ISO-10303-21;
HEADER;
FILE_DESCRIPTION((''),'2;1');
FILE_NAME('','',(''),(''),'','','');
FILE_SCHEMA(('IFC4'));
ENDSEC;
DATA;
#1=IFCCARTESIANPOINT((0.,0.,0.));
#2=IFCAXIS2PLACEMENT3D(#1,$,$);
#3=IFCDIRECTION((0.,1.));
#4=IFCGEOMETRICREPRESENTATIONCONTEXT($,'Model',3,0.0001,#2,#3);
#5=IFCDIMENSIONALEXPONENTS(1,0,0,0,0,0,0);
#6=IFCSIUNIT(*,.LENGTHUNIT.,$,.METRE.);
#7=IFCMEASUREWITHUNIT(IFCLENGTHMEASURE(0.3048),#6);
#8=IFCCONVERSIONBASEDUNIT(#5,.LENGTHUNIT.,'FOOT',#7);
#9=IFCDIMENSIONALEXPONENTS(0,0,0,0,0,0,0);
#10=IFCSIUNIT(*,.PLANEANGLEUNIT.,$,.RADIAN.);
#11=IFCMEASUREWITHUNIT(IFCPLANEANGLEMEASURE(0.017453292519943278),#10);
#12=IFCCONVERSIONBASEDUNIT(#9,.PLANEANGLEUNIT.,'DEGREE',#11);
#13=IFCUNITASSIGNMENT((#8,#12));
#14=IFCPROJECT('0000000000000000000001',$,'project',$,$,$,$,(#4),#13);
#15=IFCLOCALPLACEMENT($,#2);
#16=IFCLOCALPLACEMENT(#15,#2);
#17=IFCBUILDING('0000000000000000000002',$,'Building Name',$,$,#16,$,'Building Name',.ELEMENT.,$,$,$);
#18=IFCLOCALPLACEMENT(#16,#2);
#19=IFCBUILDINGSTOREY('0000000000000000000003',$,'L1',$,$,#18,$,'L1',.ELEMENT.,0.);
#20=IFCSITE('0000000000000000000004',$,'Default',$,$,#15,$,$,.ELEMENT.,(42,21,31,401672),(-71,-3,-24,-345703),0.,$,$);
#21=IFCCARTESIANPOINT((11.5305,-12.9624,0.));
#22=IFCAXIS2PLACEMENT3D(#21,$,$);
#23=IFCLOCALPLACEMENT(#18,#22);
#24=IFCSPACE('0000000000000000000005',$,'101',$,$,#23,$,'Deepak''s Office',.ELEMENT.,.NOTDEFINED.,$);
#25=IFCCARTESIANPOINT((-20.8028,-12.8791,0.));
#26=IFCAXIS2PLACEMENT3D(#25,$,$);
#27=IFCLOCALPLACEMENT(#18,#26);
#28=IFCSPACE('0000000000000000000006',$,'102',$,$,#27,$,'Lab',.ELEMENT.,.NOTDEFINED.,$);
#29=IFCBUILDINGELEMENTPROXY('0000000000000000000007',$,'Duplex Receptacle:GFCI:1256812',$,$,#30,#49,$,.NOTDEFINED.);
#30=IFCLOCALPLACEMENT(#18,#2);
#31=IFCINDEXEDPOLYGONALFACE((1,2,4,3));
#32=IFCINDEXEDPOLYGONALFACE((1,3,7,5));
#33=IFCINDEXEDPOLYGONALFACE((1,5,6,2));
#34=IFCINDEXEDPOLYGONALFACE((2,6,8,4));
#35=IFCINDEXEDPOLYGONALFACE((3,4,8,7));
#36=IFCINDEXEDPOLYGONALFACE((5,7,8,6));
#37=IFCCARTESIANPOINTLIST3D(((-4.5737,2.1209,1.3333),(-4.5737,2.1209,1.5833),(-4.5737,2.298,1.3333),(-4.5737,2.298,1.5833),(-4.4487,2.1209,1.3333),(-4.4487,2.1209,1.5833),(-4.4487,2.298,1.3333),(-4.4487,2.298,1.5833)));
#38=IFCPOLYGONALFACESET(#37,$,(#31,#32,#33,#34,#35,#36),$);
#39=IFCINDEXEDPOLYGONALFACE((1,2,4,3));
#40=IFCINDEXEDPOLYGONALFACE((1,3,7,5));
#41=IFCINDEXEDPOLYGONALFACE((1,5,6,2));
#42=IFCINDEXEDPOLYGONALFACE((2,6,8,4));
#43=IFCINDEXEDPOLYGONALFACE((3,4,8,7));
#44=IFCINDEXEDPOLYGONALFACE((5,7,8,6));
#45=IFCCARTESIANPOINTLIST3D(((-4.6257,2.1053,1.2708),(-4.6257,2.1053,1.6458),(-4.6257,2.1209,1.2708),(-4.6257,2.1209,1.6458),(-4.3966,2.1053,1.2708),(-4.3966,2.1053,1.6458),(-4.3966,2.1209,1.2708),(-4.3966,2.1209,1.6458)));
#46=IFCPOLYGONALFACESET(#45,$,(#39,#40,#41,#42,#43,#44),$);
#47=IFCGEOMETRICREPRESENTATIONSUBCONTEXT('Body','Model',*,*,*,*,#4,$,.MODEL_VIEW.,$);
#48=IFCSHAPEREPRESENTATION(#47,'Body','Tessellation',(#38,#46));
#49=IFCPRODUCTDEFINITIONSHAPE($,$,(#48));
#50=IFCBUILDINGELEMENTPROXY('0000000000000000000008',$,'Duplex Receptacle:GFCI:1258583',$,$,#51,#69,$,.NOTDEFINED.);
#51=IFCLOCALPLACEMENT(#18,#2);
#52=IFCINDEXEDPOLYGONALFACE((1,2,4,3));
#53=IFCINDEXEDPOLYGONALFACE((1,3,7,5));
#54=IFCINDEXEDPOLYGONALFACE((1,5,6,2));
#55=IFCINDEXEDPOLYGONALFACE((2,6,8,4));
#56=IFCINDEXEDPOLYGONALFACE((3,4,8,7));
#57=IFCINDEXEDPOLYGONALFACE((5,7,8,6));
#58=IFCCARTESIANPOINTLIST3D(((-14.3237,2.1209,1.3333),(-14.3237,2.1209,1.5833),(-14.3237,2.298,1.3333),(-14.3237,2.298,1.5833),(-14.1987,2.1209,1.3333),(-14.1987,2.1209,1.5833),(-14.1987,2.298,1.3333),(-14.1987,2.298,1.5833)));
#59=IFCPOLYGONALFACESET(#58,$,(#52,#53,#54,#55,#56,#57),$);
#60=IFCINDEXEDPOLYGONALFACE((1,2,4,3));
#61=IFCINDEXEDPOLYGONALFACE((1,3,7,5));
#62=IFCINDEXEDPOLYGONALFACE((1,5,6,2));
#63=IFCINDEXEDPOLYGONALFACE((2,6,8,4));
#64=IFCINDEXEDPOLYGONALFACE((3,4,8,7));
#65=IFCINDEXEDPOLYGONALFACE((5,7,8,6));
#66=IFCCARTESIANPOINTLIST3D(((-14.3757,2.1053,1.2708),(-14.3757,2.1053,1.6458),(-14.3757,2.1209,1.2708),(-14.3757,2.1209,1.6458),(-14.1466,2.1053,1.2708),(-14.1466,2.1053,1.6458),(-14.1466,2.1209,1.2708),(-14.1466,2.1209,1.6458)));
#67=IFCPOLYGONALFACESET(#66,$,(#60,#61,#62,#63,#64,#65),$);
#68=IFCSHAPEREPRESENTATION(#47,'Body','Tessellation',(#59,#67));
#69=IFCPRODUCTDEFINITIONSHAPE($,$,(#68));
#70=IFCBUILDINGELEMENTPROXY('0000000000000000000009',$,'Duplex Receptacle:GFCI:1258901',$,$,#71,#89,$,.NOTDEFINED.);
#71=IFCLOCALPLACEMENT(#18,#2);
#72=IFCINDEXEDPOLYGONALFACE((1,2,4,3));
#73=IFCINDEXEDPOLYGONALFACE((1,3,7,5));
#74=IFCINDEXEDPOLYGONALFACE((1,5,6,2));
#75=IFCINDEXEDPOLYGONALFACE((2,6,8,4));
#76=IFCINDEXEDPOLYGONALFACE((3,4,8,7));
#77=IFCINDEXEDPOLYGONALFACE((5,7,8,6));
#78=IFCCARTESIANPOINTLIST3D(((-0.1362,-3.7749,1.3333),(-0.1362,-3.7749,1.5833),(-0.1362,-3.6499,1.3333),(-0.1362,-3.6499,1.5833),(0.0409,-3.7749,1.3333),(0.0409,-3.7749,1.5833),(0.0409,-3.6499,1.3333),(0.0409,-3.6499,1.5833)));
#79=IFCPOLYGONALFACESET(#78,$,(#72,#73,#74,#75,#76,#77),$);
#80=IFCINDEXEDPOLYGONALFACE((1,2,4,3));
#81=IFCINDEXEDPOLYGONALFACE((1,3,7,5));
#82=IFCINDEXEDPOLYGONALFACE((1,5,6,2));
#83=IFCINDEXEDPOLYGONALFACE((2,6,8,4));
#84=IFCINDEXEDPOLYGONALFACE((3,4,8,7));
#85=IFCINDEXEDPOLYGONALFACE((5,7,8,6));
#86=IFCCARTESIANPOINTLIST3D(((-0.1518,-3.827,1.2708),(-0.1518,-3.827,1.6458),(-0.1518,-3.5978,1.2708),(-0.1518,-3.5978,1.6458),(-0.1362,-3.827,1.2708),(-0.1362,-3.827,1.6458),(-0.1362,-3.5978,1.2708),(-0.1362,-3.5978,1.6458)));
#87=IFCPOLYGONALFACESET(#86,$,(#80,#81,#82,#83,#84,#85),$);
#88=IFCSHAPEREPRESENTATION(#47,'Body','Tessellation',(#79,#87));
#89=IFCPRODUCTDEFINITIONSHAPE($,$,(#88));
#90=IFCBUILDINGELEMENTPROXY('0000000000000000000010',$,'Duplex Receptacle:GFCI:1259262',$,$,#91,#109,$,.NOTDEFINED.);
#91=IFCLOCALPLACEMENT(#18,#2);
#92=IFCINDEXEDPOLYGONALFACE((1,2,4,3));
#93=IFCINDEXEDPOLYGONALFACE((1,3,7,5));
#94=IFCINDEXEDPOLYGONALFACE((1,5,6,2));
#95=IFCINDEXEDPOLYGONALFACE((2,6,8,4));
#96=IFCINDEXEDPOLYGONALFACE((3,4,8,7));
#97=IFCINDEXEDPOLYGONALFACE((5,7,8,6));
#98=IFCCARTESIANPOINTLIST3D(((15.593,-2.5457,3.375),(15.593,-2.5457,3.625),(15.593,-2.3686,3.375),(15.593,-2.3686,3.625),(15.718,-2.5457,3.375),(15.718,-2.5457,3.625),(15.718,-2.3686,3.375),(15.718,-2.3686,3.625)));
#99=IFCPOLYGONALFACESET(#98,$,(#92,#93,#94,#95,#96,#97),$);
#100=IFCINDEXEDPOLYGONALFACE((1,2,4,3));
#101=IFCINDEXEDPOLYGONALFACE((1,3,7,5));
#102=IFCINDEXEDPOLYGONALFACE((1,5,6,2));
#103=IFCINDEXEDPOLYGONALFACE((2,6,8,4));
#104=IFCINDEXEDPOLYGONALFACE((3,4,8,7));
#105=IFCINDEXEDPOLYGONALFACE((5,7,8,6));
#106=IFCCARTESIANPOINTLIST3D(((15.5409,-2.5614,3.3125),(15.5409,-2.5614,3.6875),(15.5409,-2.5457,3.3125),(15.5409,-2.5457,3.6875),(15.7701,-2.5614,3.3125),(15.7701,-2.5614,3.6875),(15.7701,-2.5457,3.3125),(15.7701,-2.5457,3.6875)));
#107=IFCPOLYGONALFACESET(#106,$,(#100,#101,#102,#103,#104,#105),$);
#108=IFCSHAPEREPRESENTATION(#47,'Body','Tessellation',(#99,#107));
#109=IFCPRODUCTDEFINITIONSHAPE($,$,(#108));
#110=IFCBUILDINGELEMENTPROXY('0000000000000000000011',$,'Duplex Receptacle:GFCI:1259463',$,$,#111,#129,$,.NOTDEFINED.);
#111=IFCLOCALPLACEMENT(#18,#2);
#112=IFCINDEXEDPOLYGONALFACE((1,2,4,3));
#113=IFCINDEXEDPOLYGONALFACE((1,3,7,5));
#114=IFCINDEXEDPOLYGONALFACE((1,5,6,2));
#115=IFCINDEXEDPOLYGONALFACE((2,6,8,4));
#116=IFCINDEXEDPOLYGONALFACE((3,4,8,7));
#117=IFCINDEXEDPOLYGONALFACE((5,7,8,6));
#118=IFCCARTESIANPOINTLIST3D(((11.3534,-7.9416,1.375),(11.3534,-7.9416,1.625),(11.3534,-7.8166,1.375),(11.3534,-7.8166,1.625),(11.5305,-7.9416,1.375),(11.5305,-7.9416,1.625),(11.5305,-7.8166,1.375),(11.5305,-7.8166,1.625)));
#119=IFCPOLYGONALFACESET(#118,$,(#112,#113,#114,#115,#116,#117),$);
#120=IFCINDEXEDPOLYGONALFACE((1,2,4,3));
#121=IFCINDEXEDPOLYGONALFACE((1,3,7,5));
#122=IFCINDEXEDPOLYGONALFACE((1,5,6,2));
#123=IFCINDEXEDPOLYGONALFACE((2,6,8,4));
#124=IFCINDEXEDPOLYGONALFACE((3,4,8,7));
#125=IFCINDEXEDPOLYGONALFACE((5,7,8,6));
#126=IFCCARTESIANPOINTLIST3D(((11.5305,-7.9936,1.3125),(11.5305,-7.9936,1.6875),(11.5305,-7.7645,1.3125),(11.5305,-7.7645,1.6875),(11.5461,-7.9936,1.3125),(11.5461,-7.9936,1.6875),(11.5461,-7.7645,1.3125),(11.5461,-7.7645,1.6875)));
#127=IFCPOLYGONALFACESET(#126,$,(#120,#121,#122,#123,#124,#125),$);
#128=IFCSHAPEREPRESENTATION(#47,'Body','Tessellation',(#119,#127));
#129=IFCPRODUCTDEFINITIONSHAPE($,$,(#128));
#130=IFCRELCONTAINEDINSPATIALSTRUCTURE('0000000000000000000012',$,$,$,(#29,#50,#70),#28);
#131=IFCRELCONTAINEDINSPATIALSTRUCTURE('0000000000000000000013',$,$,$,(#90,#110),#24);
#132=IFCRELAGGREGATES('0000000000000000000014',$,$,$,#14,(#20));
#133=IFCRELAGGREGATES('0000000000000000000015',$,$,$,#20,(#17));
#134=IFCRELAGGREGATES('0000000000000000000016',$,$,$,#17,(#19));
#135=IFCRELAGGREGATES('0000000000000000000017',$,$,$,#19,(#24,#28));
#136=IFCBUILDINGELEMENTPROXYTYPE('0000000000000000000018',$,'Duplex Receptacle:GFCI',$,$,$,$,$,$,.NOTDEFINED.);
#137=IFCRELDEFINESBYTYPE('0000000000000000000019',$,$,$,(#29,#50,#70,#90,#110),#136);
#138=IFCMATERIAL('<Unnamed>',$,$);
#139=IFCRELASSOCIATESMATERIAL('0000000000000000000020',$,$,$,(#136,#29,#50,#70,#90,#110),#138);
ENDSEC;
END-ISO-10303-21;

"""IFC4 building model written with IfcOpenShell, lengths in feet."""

from ifc_helpers import new_model, entity, si_unit, converted_unit, direction, frame, origin, place, context, subcontext, project, spatial, indexed_curve, outline, extrude, source, transform, mapped, material, type_object, type_shapes, element, save


model = new_model("IFC4")

# Units and contexts
model_context = context("Model", 3, precision=0.0001, world=origin(), true_north=direction((0.0, 1.0)))
body_context = subcontext(model_context, "Body", "Model", "MODEL_VIEW")
ifc_project = project(units=[converted_unit("LENGTHUNIT", "FOOT", entity("IfcLengthMeasure", 0.3048), si_unit("LENGTHUNIT", "METRE"), dimensions=[1, 0, 0, 0, 0, 0, 0]), converted_unit("PLANEANGLEUNIT", "DEGREE", entity("IfcPlaneAngleMeasure", 0.017453292519943278), si_unit("PLANEANGLEUNIT", "RADIAN"), dimensions=[0, 0, 0, 0, 0, 0, 0])], contexts=[model_context])

# Site, building, storey
site_placement = place(None, origin())
site = spatial("IfcSite", under=ifc_project, at=site_placement, Name="Default", CompositionType="ELEMENT", RefLatitude=(42, 21, 31, 401672), RefLongitude=(-71, -3, -24, -345703), RefElevation=0.0)
building_placement = place(site_placement, origin())
building = spatial("IfcBuilding", under=site, at=building_placement, Name="Building Name", LongName="Building Name", CompositionType="ELEMENT")
storey_placement = place(building_placement, origin())
storey = spatial("IfcBuildingStorey", under=building, at=storey_placement, Name="L1", LongName="L1", CompositionType="ELEMENT", Elevation=0.0)

# Shared definitions
space_1_placement = place(storey_placement, frame((11.5305, -12.9624, 0.0)))
space_1 = spatial("IfcSpace", under=storey, at=space_1_placement, Name="101", LongName="Deepak's Office", CompositionType="ELEMENT", PredefinedType="NOTDEFINED")

# Shared definitions
space_2_placement = place(storey_placement, frame((-20.8028, -12.8791, 0.0)))
space_2 = spatial("IfcSpace", under=storey, at=space_2_placement, Name="102", LongName="Lab", CompositionType="ELEMENT", PredefinedType="NOTDEFINED")

# Building element proxies
ifc_material_1 = material(Name="<Unnamed>")
building_element_proxy_type_1 = type_object("IfcBuildingElementProxyType", Name="Duplex Receptacle:GFCI", PredefinedType="NOTDEFINED", material=ifc_material_1)
shared_shape_1 = source(origin(), body_context, "Body", "SweptSolid", [
    extrude(outline(indexed_curve([(-0.0625, -0.125), (0.0625, -0.125), (0.0625, 0.125), (-0.0625, 0.125), (-0.0625, -0.125)], self_intersect=False)), frame((0.0, 0.0, -0.1771), z_axis=(0.0, 0.0, 1.0), x_axis=(-1.0, 0.0, 0.0)), (0.0, 0.0, 1.0), 0.1771),
    extrude(outline(indexed_curve([(-0.1146, -0.1875), (0.1146, -0.1875), (0.1146, 0.1875), (-0.1146, 0.1875), (-0.1146, -0.1875)], self_intersect=False)), frame((0.0, 0.0, 0.0), z_axis=(0.0, 0.0, 1.0), x_axis=(-1.0, 0.0, 0.0)), (0.0, 0.0, 1.0), 0.0156),
])
type_shapes(building_element_proxy_type_1, [shared_shape_1])
for number, where, z_axis, x_axis, name in (
    (1, (16.2917, 15.0, 1.4583), (0.0, -1.0, 0.0), (1.0, 0.0, 0.0), "Duplex Receptacle:GFCI:1256812"),
    (2, (6.5417, 15.0, 1.4583), (0.0, -1.0, 0.0), (1.0, 0.0, 0.0), "Duplex Receptacle:GFCI:1258583"),
    (3, (20.6667, 9.1667, 1.4583), (-1.0, 0.0, 0.0), (0.0, -1.0, 0.0), "Duplex Receptacle:GFCI:1258901"),
):
    element("IfcBuildingElementProxy", number, at=place(space_2_placement, frame(where, z_axis=z_axis, x_axis=x_axis)), inside=space_2, type_object=building_element_proxy_type_1, material=ifc_material_1, Name=name, PredefinedType="NOTDEFINED", context=body_context, shape_type="MappedRepresentation", body=[
        mapped(shared_shape_1, transform((0.0, 0.0, 0.0), scale=1.0)),
    ])
for number, where, z_axis, x_axis, name in (
    (4, (4.125, 10.4167, 3.5), (0.0, -1.0, 0.0), (1.0, 0.0, 0.0), "Duplex Receptacle:GFCI:1259262"),
    (5, (0.0, 5.0833, 1.5), (1.0, 0.0, 0.0), (0.0, 1.0, 0.0), "Duplex Receptacle:GFCI:1259463"),
):
    element("IfcBuildingElementProxy", number, at=place(space_1_placement, frame(where, z_axis=z_axis, x_axis=x_axis)), inside=space_1, type_object=building_element_proxy_type_1, material=ifc_material_1, Name=name, PredefinedType="NOTDEFINED", context=body_context, shape_type="MappedRepresentation", body=[
        mapped(shared_shape_1, transform((0.0, 0.0, 0.0), scale=1.0)),
    ])

save(model, "model.ifc")
